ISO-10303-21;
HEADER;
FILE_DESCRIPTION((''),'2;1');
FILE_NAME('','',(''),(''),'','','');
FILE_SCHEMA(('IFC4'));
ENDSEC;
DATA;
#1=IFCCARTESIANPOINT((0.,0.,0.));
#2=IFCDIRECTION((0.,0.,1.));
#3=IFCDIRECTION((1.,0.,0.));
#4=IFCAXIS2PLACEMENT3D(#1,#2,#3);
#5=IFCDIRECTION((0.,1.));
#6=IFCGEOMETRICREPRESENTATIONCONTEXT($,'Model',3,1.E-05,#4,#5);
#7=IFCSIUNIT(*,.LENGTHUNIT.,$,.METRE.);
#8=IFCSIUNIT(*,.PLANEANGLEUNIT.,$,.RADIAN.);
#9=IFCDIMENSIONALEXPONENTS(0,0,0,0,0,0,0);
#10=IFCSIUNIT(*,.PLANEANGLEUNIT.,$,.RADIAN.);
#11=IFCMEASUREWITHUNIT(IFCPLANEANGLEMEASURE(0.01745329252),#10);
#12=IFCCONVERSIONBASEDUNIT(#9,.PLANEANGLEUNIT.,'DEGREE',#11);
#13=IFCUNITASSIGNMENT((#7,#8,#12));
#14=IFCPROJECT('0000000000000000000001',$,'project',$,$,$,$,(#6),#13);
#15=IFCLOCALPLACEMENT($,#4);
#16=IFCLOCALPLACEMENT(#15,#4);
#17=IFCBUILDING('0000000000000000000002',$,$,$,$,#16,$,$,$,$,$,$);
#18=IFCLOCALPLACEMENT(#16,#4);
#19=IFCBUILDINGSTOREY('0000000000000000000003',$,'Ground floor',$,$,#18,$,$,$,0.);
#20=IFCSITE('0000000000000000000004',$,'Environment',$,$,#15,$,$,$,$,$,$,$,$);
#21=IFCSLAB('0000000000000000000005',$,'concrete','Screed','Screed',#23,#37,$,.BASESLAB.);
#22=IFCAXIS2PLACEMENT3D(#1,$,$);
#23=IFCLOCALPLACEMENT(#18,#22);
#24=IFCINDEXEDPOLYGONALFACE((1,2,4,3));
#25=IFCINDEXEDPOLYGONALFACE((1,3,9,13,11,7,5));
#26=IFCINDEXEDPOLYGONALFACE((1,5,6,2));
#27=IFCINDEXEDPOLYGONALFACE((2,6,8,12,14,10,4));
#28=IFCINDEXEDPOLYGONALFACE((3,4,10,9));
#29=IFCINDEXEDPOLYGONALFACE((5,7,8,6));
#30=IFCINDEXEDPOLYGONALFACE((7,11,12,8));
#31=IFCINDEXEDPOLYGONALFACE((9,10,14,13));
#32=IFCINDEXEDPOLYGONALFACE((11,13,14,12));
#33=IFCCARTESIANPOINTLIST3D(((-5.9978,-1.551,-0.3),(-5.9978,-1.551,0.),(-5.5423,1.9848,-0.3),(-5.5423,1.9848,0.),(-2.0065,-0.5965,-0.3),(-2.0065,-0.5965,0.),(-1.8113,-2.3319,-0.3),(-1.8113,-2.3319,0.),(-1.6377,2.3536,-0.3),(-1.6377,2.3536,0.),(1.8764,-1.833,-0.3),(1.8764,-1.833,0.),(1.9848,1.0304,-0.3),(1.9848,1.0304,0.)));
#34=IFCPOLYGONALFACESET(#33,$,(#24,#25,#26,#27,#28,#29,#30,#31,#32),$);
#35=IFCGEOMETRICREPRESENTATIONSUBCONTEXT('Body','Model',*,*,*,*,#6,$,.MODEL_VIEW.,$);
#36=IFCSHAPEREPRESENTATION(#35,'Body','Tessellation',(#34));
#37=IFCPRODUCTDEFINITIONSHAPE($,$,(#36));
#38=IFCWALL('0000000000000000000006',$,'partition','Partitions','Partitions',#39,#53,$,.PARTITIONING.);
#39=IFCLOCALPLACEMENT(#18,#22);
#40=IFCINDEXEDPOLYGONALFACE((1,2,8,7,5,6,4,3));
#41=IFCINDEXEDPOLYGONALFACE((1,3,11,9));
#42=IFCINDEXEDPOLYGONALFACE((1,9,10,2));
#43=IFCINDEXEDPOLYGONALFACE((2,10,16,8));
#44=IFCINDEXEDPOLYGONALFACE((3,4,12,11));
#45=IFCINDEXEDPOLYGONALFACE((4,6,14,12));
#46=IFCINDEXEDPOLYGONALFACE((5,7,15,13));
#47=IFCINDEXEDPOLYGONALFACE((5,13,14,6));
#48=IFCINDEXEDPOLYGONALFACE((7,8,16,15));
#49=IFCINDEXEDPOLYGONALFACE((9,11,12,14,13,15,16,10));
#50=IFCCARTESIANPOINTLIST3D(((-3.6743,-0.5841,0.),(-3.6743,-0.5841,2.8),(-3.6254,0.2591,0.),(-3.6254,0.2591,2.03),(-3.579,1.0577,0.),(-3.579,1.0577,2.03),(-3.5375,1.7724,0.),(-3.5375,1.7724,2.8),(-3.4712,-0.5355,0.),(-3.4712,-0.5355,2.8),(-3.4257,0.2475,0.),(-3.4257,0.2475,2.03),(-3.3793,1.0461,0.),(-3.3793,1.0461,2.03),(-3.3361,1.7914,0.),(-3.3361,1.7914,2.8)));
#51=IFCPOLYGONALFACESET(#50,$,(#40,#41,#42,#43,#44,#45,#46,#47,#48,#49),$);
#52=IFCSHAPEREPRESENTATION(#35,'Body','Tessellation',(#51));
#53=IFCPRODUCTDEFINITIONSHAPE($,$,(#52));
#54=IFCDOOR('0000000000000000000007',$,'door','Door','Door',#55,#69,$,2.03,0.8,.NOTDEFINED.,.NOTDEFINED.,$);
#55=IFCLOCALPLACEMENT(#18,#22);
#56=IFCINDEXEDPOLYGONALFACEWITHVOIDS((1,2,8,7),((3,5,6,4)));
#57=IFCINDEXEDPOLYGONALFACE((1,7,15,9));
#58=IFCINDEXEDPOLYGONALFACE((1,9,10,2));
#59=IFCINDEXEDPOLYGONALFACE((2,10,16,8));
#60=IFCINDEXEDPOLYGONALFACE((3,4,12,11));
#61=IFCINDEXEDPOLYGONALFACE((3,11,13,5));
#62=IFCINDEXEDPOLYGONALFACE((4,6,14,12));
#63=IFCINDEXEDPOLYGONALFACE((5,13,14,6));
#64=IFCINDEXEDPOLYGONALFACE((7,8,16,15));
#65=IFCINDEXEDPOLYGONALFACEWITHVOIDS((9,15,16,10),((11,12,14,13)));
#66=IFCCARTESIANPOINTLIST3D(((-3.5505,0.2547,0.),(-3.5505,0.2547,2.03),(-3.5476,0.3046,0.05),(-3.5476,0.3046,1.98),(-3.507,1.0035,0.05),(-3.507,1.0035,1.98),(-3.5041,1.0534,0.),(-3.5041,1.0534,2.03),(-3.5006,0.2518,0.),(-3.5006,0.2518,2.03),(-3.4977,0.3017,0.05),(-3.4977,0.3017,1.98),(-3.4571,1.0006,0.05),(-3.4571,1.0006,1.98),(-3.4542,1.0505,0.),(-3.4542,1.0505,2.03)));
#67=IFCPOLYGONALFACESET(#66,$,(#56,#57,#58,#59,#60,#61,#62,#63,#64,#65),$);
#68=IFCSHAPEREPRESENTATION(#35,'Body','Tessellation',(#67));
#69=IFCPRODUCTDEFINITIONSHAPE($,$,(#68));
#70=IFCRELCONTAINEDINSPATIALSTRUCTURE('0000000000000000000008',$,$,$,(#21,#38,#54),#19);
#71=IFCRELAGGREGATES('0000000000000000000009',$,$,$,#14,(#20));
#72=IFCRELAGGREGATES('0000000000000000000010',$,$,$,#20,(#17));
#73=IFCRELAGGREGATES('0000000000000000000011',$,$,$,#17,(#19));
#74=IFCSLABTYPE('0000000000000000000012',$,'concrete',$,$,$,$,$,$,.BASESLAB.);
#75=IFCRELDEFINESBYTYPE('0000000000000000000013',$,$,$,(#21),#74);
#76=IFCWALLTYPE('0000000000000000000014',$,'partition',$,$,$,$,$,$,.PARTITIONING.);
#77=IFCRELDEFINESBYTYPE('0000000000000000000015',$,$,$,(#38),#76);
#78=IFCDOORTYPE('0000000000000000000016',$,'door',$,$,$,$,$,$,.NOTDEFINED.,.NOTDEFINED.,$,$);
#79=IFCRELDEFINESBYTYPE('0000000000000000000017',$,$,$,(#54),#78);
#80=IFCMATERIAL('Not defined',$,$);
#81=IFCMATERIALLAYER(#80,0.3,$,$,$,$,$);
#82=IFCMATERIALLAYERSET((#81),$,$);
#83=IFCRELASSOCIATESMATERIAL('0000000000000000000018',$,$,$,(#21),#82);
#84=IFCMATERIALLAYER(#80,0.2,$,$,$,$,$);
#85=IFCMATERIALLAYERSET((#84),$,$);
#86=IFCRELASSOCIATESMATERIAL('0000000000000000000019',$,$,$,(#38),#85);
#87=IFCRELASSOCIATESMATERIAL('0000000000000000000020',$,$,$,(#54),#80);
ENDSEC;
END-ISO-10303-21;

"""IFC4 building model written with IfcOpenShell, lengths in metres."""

from ifc_helpers import new_model, entity, si_unit, converted_unit, direction, frame, origin_with_axes, origin_2d_with_axis, place, context, subcontext, project, spatial, polyline, rectangle, hollow_rectangle, outline, extrude, shape, material, layer, layer_set, layer_usage, type_object, element, fill, save


model = new_model("IFC4")

# Units and contexts
model_context = context("Model", 3, precision=1e-05, world=origin_with_axes(), true_north=direction((0.0, 1.0)))
body_context = subcontext(model_context, "Body", "Model", "MODEL_VIEW")
footprint_context = subcontext(model_context, "FootPrint", "Model", "MODEL_VIEW")
ifc_project = project(units=[si_unit("LENGTHUNIT", "METRE"), si_unit("PLANEANGLEUNIT", "RADIAN"), converted_unit("PLANEANGLEUNIT", "DEGREE", entity("IfcPlaneAngleMeasure", 0.01745329252), si_unit("PLANEANGLEUNIT", "RADIAN"), dimensions=[0, 0, 0, 0, 0, 0, 0])], contexts=[model_context])

# Site, building, storey
site_placement = place(None, origin_with_axes())
site = spatial("IfcSite", under=ifc_project, at=site_placement, Name="Environment")
building_placement = place(site_placement, origin_with_axes())
building = spatial("IfcBuilding", under=site, at=building_placement)
storey_placement = place(building_placement, origin_with_axes())
storey = spatial("IfcBuildingStorey", under=building, at=storey_placement, Name="Ground floor", Elevation=0.0)

# Slab
ifc_material = material(Name="Not defined")
ifc_layer_1 = layer(ifc_material, 0.3)
ifc_layer_set_1 = layer_set([ifc_layer_1])
ifc_layer_usage_1 = layer_usage(ifc_layer_set_1, "AXIS3", "POSITIVE", 0.0)
slab_type = type_object("IfcSlabType", Name="concrete", PredefinedType="BASESLAB")
slab_placement = place(storey_placement, frame((-5.9978, -1.551, -0.3), z_axis=(0.0, 0.0, 1.0), x_axis=(1.0, 0.0, 0.0)))
element("IfcSlab", 1, at=slab_placement, inside=storey, type_object=slab_type, material=ifc_layer_usage_1, Name="concrete", Description="Screed", ObjectType="Screed", PredefinedType="BASESLAB", context=body_context, shape_type="SweptSolid", body=[
    extrude(outline(polyline([(0.0, 0.0), (3.9913, 0.9544), (4.1866, -0.7809), (7.8742, -0.282), (7.9826, 2.5813), (4.3601, 3.9046), (0.4555, 3.5358), (0.0, 0.0)])), origin_with_axes(), (0.0, 0.0, 1.0), 0.3),
])

# Shared definitions
door_type = type_object("IfcDoorType", Name="door", OperationType="NOTDEFINED", PredefinedType="NOTDEFINED")

# Wall, opening, door
ifc_layer_2 = layer(ifc_material, 0.2)
ifc_layer_set_2 = layer_set([ifc_layer_2])
ifc_layer_usage_2 = layer_usage(ifc_layer_set_2, "AXIS2", "POSITIVE", 0.0)
wall_type_1 = type_object("IfcWallType", Name="partition", PredefinedType="PARTITIONING")
wall_1_placement = place(storey_placement, frame((-3.4954, -0.9526, 0.0), z_axis=(0.0, 0.0, 1.0), x_axis=(0.057974, 0.998318, 0.0)))
cartesian_point_1 = entity("IfcCartesianPoint", [-1.1802, -1.4])
cartesian_point_2 = entity("IfcCartesianPoint", [-1.1654, -1.4])
wall_1 = element("IfcWall", 2, at=wall_1_placement, inside=storey, type_object=wall_type_1, material=ifc_layer_usage_2, Name="partition", Description="Partitions", ObjectType="Partitions", PredefinedType="PARTITIONING", context=body_context, shape_type="SolidModel", body=[
    entity("IfcExtrudedAreaSolidTapered", entity("IfcArbitraryClosedProfileDef", "AREA", None, entity("IfcPolyline", [cartesian_point_1, entity("IfcCartesianPoint", [1.1802, -1.4]), entity("IfcCartesianPoint", [1.1802, 1.4]), entity("IfcCartesianPoint", [-1.1802, 1.4]), cartesian_point_1])), entity("IfcAxis2Placement3D", entity("IfcCartesianPoint", [1.5377, 0.2, 1.4]), entity("IfcDirection", [0.0, -1.0, 0.0]), entity("IfcDirection", [1.0, 0.0, 0.0])), entity("IfcDirection", [0.221725, 0.0, 0.975109]), 0.2051, entity("IfcArbitraryClosedProfileDef", "AREA", None, entity("IfcPolyline", [cartesian_point_2, entity("IfcCartesianPoint", [1.1654, -1.4]), entity("IfcCartesianPoint", [1.1654, 1.4]), entity("IfcCartesianPoint", [-1.1654, 1.4]), cartesian_point_2]))),
])
opening_1_placement = place(wall_1_placement, frame((1.6021, 0.1, 1.015), z_axis=(0.0, 0.0, 1.0), x_axis=(1.0, 0.0, 0.0)))
cartesian_point_3 = entity("IfcCartesianPoint", [-0.4, -0.1])
opening_1 = element("IfcOpeningElement", 3, at=opening_1_placement, cuts=wall_1, ObjectType="Not defined", PredefinedType="OPENING", shapes=[
    shape(body_context, "Body", "SweptSolid", [extrude(rectangle(XDim=2.03, YDim=0.8, at=origin_2d_with_axis()), frame((0.0, -0.1, 0.0), z_axis=(0.0, 1.0, 0.0), x_axis=(0.0, 0.0, 1.0)), (0.0, 0.0, 1.0), 0.2)]),
    shape(footprint_context, "FootPrint", "GeometricCurveSet", [entity("IfcGeometricCurveSet", [entity("IfcPolyline", [cartesian_point_3, entity("IfcCartesianPoint", [0.4, -0.1]), entity("IfcCartesianPoint", [0.4, 0.1]), entity("IfcCartesianPoint", [-0.4, 0.1]), cartesian_point_3])])]),
])
door_1_placement = place(opening_1_placement, origin_with_axes())
door_1 = element("IfcDoor", 4, at=door_1_placement, inside=storey, type_object=door_type, material=ifc_material, Name="door", Description="Door", ObjectType="Door", OperationType="NOTDEFINED", OverallHeight=2.03, OverallWidth=0.8, PredefinedType="NOTDEFINED", context=body_context, shape_type="SweptSolid", body=[
    extrude(hollow_rectangle(XDim=0.8, YDim=2.03, WallThickness=0.05, InnerFilletRadius=0.0, OuterFilletRadius=0.0, at=origin_2d_with_axis()), frame((0.0, 0.025, 0.0), z_axis=(0.0, -1.0, 0.0), x_axis=(1.0, 0.0, 0.0)), (0.0, 0.0, 1.0), 0.05),
])
fill(opening_1, door_1)

save(model, "model.ifc")
